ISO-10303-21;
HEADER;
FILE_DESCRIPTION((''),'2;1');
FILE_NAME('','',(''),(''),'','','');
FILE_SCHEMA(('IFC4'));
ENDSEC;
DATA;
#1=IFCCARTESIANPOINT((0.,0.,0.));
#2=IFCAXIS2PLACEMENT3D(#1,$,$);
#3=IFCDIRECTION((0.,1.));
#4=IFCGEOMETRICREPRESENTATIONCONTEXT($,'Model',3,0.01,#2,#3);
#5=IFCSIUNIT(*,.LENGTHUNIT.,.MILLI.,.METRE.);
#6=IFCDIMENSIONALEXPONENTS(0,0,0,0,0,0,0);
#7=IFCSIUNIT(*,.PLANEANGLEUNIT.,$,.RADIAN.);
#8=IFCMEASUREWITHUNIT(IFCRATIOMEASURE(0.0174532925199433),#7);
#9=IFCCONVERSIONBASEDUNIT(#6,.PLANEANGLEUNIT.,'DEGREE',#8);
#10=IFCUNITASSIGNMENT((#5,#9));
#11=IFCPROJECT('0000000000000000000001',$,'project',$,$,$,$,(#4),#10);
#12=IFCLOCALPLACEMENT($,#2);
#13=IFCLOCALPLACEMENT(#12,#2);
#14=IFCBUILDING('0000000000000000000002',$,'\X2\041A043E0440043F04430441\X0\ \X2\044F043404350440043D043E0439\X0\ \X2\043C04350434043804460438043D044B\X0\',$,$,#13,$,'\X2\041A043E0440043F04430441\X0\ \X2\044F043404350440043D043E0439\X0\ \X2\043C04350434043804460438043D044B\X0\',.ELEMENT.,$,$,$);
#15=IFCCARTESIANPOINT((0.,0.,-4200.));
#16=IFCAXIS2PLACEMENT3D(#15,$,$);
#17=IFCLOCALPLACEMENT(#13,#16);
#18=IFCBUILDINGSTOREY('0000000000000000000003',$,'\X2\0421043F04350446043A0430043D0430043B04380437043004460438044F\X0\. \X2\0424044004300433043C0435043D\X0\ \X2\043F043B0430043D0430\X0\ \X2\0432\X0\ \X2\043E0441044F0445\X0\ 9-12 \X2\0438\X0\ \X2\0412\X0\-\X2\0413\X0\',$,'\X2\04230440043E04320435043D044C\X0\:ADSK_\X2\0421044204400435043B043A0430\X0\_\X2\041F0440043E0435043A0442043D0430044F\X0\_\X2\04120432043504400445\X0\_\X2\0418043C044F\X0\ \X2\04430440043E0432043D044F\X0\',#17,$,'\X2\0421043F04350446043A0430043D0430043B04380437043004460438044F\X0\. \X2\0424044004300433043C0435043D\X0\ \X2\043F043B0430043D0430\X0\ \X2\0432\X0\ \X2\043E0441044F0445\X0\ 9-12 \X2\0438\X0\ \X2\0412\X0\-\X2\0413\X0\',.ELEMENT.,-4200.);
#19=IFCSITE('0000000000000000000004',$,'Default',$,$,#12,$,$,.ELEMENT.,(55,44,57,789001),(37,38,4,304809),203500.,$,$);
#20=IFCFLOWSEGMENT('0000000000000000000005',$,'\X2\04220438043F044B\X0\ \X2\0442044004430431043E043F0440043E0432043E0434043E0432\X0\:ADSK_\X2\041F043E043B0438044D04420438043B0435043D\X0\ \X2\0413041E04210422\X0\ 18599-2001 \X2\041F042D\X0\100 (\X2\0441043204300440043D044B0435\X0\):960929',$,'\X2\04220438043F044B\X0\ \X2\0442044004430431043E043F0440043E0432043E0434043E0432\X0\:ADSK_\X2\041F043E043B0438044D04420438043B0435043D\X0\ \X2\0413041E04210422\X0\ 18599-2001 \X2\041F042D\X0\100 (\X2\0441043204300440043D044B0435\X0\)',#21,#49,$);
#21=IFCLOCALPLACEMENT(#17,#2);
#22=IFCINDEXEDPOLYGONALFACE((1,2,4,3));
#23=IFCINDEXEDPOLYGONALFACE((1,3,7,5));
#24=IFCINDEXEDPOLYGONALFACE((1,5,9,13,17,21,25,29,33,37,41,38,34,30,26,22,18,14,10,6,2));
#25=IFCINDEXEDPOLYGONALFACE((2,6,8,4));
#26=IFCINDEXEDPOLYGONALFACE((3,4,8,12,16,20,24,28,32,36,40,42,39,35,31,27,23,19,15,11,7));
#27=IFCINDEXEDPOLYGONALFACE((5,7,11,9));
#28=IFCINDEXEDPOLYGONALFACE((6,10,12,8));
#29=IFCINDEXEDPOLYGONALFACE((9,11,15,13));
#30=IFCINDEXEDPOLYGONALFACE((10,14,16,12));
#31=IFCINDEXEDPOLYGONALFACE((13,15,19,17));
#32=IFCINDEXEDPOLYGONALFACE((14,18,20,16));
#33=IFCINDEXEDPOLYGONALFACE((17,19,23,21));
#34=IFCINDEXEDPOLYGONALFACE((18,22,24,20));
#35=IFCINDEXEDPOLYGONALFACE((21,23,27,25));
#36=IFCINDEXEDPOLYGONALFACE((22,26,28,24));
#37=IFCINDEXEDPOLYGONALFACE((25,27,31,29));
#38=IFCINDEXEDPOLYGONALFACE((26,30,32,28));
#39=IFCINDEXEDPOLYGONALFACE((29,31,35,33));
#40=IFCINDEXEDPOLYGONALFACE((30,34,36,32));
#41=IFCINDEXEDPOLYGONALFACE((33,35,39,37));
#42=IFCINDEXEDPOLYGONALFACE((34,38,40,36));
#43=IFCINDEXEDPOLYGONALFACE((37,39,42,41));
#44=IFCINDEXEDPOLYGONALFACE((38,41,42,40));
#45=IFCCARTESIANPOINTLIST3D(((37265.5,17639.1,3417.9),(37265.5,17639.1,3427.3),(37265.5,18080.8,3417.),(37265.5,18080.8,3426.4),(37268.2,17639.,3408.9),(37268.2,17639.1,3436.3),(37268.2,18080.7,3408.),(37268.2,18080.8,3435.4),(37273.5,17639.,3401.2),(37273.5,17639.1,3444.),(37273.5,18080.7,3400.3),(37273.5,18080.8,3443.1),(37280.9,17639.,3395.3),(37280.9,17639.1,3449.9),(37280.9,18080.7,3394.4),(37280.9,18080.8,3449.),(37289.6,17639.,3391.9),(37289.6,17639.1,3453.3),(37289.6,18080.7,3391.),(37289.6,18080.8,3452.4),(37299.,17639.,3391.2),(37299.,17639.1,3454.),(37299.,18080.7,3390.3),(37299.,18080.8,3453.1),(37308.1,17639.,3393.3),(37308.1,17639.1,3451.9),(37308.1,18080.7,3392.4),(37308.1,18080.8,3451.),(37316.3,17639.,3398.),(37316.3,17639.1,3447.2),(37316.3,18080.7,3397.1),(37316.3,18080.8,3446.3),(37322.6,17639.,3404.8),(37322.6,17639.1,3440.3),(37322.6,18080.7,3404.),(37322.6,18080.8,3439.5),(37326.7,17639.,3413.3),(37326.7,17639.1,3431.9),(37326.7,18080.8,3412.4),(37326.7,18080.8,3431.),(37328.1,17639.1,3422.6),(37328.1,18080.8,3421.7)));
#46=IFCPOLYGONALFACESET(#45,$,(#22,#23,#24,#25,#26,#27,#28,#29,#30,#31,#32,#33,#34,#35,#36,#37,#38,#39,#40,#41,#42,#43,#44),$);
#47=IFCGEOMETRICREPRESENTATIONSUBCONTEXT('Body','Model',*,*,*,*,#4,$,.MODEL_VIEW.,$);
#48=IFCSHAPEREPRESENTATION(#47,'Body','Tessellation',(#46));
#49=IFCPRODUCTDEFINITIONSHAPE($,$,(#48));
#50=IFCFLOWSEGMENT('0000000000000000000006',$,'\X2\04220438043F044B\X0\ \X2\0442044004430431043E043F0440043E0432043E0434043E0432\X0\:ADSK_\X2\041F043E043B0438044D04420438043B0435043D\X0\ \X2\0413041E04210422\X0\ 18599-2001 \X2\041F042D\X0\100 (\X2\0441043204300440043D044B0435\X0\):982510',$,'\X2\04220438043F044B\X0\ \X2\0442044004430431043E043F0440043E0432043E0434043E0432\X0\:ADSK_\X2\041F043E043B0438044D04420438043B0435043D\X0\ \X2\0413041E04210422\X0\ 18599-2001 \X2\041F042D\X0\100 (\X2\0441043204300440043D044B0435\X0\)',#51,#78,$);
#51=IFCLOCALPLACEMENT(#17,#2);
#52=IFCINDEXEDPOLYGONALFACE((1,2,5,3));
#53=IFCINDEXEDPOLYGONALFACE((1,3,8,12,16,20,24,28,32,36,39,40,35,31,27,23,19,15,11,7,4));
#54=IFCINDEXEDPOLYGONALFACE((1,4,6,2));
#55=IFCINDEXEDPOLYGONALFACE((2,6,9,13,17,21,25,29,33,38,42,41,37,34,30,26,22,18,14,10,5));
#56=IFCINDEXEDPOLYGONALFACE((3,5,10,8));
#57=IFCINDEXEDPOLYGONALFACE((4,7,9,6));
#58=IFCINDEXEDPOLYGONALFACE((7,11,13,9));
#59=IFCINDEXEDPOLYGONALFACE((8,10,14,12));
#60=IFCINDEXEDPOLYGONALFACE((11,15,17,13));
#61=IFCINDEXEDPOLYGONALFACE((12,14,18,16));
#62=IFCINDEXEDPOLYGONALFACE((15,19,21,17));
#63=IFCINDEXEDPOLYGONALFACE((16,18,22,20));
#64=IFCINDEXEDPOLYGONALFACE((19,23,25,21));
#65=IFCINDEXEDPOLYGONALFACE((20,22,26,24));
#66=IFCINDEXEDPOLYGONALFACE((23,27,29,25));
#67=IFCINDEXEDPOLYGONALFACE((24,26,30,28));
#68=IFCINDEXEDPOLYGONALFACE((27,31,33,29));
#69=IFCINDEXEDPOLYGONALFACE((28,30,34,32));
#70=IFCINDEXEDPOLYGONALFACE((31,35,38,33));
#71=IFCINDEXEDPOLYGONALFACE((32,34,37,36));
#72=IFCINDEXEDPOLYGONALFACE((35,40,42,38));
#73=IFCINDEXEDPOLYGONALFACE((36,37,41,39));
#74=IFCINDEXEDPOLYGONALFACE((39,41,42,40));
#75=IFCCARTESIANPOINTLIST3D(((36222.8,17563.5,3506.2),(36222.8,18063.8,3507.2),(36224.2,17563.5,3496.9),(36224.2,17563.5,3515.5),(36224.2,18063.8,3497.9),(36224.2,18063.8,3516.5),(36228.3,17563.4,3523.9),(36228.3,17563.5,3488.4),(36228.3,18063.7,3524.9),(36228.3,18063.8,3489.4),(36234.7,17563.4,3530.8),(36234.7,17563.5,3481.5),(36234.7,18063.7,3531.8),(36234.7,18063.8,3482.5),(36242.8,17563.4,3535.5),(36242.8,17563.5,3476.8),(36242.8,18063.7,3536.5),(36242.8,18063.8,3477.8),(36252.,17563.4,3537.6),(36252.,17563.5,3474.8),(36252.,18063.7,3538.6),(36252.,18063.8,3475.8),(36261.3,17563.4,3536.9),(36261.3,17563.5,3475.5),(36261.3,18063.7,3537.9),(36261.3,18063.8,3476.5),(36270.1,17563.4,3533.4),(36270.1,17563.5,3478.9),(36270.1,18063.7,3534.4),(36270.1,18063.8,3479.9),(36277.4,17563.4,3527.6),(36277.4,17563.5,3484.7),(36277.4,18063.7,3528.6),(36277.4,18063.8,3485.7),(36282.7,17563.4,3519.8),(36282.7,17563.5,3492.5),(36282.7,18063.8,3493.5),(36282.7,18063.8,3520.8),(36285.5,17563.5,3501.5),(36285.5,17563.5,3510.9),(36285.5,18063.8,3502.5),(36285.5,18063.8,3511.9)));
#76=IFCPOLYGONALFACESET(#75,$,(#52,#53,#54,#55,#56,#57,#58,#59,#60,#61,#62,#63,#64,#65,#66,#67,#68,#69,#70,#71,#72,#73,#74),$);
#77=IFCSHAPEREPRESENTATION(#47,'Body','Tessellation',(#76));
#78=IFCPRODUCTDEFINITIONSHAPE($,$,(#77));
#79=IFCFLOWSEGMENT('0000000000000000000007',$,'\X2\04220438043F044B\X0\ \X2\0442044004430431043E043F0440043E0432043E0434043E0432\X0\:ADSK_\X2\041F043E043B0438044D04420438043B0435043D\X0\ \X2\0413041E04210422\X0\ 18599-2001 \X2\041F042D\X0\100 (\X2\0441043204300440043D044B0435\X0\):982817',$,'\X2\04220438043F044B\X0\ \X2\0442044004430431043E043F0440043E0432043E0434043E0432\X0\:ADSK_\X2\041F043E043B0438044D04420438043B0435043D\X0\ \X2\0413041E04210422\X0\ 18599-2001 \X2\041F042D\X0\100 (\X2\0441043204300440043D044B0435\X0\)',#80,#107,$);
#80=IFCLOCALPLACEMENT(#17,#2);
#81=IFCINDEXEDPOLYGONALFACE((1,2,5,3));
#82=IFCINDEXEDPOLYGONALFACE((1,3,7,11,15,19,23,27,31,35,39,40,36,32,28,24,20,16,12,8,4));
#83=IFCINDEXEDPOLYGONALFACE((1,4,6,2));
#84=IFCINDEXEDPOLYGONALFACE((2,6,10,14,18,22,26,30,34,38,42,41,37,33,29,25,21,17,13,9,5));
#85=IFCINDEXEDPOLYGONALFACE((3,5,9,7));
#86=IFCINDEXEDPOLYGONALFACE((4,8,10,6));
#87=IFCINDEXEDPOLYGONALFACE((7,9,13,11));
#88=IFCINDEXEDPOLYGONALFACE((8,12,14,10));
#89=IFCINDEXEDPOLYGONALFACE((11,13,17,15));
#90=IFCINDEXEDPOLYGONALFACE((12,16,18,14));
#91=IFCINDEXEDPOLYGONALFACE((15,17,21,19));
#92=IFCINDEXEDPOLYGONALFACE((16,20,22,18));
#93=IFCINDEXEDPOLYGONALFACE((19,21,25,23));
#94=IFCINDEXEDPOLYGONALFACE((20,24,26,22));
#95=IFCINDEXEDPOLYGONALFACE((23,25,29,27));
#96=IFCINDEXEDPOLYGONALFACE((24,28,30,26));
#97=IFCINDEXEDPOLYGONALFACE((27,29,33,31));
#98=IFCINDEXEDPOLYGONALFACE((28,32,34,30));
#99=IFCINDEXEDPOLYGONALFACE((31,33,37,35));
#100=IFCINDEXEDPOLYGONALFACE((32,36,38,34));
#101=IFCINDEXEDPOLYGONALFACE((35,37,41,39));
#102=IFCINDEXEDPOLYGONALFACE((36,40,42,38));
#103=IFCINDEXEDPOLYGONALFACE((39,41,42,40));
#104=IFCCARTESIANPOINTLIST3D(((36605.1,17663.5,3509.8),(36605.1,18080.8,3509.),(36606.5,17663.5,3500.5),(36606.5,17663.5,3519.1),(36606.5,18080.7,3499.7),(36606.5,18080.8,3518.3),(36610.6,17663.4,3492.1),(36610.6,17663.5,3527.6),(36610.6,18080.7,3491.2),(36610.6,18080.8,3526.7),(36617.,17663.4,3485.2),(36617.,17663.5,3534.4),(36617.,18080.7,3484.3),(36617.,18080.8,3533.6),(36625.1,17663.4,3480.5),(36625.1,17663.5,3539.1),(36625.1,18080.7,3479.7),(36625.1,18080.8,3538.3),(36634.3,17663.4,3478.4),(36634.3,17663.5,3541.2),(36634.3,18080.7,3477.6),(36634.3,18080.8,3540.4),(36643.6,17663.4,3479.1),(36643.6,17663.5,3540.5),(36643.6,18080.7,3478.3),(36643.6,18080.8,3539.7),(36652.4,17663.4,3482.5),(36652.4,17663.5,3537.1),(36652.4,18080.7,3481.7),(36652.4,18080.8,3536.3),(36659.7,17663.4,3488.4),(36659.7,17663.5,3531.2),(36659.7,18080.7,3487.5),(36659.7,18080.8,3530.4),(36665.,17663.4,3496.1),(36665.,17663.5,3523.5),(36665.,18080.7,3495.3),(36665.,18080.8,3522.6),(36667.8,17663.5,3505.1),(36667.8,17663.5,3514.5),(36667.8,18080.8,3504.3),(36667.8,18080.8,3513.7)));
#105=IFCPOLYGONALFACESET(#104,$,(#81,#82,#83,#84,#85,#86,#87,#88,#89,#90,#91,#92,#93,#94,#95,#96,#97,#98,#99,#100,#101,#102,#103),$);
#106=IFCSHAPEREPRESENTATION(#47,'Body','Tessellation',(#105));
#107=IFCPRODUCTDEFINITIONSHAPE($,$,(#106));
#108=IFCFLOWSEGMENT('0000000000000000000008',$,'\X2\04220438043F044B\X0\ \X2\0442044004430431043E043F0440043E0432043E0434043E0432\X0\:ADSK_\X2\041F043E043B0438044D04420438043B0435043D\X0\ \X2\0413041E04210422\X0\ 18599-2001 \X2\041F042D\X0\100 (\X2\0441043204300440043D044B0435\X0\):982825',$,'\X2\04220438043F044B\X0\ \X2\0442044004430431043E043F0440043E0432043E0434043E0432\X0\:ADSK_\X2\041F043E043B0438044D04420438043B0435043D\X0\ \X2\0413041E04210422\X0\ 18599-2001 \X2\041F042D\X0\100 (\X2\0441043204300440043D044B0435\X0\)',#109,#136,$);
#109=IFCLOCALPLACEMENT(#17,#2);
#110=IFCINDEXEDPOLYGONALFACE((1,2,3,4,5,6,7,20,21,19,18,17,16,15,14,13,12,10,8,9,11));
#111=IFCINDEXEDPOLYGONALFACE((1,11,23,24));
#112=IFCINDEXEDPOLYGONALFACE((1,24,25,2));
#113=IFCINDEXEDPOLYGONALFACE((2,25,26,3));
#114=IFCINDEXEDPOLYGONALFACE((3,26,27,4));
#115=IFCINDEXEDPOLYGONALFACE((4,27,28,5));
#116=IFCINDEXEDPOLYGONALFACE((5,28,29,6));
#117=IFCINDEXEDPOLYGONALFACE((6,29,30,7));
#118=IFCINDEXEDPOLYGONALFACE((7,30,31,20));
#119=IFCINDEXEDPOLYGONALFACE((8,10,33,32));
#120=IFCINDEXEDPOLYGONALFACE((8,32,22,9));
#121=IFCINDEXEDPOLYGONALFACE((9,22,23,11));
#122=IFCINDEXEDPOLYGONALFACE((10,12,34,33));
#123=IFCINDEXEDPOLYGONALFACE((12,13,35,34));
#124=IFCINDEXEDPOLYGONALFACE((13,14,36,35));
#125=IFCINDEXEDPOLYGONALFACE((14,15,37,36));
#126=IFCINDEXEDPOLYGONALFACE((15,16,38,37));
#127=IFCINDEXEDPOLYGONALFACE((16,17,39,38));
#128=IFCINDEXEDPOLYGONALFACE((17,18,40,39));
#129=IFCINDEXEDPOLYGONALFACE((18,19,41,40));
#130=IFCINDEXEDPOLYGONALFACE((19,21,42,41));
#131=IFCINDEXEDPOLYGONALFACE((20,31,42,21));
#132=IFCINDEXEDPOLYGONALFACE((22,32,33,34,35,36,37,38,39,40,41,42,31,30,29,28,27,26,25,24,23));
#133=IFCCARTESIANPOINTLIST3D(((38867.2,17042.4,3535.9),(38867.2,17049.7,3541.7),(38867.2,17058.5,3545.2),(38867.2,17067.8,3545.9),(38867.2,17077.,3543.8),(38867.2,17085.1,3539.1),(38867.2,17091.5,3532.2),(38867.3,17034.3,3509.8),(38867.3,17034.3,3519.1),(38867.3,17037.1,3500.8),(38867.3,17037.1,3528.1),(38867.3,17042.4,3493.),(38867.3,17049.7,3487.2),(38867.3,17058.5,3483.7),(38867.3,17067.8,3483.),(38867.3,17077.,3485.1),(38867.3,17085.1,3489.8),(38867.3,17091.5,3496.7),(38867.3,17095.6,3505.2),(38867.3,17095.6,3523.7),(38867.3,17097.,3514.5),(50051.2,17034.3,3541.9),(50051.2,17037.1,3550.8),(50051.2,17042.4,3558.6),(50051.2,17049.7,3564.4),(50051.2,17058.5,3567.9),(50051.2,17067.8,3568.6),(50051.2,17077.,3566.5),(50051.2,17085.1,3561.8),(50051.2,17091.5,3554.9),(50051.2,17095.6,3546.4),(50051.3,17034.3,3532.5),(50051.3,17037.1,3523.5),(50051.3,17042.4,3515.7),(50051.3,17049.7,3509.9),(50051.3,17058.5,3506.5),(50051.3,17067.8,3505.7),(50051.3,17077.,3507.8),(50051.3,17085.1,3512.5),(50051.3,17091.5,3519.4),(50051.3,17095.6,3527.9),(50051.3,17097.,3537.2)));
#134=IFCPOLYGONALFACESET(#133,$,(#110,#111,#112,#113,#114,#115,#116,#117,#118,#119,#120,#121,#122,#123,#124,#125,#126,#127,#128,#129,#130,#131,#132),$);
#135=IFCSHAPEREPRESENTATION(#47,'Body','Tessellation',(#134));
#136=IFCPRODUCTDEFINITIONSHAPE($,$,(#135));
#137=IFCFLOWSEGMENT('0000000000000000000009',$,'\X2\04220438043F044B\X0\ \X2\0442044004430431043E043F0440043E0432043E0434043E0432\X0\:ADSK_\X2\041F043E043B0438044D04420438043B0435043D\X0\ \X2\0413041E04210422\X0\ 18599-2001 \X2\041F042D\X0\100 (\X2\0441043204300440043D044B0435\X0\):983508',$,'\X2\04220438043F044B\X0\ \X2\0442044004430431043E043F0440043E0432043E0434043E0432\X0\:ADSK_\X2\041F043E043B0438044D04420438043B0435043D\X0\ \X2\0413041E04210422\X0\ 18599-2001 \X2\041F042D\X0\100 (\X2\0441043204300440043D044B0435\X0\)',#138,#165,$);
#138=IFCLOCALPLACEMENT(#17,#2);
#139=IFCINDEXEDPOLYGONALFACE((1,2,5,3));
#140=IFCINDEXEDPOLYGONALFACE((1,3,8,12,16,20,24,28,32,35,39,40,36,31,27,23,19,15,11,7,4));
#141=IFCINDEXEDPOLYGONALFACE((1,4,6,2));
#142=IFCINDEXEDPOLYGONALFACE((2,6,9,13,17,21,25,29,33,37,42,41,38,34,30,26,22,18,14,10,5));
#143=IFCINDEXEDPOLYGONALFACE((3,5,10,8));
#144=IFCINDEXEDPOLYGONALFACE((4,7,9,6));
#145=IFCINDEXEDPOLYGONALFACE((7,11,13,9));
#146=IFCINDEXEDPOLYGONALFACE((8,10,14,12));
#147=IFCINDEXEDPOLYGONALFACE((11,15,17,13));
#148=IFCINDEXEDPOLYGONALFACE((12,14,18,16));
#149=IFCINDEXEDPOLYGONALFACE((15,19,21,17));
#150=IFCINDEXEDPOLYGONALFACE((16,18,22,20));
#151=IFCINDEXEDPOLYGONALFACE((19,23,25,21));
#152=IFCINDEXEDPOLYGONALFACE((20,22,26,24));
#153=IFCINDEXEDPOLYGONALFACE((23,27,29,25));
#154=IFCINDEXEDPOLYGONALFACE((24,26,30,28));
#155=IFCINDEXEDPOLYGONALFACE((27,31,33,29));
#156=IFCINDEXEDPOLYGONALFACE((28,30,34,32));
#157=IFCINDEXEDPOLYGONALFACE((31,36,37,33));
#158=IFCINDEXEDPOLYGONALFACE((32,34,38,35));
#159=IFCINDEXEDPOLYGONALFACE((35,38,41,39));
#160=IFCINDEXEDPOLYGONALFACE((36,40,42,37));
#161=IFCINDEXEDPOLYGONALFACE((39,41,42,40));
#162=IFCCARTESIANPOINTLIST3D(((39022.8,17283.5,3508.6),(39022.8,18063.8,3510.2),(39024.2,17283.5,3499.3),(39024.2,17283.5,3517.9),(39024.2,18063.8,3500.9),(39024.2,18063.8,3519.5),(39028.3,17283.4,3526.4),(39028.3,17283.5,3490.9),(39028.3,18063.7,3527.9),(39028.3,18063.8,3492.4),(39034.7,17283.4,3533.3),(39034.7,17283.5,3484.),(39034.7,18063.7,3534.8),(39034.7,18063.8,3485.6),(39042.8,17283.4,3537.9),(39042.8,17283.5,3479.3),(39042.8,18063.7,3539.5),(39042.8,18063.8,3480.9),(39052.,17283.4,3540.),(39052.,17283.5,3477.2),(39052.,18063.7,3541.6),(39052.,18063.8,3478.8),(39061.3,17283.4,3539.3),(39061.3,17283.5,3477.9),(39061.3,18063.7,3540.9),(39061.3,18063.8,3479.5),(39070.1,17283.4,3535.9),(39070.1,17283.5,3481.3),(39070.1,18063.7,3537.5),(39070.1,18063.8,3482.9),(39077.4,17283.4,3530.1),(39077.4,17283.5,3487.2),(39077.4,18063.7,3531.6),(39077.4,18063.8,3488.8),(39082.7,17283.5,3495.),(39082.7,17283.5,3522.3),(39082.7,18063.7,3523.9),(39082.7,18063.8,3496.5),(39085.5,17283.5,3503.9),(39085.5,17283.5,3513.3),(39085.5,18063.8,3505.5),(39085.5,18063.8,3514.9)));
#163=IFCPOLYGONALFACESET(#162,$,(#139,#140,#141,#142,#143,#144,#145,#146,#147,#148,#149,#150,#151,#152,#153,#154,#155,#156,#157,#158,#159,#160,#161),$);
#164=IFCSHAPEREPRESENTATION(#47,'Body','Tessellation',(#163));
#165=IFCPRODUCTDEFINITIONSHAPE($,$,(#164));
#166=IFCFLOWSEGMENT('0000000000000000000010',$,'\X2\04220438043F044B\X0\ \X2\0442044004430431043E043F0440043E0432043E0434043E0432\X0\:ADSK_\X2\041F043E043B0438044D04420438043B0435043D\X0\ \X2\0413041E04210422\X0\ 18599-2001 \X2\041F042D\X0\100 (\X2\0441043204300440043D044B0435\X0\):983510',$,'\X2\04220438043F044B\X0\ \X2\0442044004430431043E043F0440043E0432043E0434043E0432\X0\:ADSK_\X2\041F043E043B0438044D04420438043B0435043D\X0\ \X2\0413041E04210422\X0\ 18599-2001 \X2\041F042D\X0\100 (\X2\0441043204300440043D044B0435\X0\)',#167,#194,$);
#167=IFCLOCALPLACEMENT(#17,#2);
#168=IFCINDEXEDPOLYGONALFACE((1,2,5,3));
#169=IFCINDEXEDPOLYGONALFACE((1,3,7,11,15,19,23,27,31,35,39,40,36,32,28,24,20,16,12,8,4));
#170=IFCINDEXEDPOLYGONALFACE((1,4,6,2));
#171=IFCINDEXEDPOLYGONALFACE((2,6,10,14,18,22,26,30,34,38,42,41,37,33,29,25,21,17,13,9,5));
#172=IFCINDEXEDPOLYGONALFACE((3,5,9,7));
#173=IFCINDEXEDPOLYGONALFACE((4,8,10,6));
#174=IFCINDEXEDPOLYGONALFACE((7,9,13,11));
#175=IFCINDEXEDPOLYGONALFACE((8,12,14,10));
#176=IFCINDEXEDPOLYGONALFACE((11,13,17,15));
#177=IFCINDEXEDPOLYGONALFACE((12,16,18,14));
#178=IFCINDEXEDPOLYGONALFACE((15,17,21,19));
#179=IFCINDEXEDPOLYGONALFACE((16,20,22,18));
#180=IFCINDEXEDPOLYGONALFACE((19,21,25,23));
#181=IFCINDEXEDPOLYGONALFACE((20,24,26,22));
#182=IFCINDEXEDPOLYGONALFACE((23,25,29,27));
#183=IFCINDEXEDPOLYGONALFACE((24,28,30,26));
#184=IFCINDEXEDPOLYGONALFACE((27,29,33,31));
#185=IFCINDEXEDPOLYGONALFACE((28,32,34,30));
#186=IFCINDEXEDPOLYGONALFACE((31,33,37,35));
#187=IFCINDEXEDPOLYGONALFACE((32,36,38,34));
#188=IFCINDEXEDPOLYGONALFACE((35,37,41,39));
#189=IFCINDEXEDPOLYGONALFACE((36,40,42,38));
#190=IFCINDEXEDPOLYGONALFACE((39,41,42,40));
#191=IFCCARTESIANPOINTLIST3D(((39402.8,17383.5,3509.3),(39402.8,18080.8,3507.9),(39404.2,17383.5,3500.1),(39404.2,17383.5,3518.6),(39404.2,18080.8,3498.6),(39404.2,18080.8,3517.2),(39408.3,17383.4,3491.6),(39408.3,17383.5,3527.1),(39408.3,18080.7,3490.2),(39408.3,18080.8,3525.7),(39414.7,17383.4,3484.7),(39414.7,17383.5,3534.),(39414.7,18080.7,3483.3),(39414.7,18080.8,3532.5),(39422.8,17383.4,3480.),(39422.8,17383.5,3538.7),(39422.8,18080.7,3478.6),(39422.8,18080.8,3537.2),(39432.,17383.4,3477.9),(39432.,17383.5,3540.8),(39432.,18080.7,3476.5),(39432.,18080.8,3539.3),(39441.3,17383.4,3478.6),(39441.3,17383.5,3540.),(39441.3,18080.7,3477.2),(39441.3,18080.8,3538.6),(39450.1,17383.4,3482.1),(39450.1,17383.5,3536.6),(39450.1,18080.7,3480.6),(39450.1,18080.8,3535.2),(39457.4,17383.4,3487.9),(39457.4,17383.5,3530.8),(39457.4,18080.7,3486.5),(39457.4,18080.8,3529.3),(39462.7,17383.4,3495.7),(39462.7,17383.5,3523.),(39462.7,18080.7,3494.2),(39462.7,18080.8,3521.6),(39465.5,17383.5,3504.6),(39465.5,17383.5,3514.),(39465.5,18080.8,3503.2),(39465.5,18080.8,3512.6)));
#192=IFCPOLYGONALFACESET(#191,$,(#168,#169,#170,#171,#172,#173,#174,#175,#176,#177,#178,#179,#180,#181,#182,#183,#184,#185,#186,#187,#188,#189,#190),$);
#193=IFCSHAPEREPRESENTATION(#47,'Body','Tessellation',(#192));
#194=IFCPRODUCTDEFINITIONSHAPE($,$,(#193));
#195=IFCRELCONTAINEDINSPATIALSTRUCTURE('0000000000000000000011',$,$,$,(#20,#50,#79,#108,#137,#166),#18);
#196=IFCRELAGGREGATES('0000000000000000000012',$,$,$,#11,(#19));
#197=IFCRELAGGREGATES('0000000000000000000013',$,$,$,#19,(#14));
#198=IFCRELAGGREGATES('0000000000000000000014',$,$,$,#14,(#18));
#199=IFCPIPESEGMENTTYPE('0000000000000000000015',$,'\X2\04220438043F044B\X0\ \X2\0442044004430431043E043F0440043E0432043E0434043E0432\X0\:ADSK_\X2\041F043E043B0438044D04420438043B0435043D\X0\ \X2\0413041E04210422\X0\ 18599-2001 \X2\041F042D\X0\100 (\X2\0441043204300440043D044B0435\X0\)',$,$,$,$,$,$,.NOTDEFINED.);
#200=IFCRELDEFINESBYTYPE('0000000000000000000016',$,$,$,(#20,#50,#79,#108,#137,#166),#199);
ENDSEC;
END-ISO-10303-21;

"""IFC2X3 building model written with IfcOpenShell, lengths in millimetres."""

from ifc_helpers import new_model, entity, si_unit, converted_unit, direction, frame, frame_2d, origin, origin_2d_with_axis, place, context, subcontext, project, spatial, circle, extrude, type_object, element, save


model = new_model("IFC2X3")

# Units and contexts
model_context = context("Model", 3, precision=0.01, world=origin(), true_north=direction((0.0, 1.0)))
body_context = subcontext(model_context, "Body", "Model", "MODEL_VIEW")
ifc_project = project(units=[si_unit("LENGTHUNIT", "METRE", prefix="MILLI"), converted_unit("PLANEANGLEUNIT", "DEGREE", entity("IfcRatioMeasure", 0.0174532925199433), si_unit("PLANEANGLEUNIT", "RADIAN"), dimensions=[0, 0, 0, 0, 0, 0, 0])], contexts=[model_context])

# Site, building, storey
site_placement = place(None, frame((0.0, 0.0, 0.0)))
site = spatial("IfcSite", under=ifc_project, at=site_placement, Name="Default", CompositionType="ELEMENT", RefLatitude=(55, 44, 57, 789001), RefLongitude=(37, 38, 4, 304809), RefElevation=203500.0)
building_placement = place(site_placement, origin())
building = spatial("IfcBuilding", under=site, at=building_placement, Name="Корпус ядерной медицины", LongName="Корпус ядерной медицины", CompositionType="ELEMENT")
storey_placement = place(building_placement, frame((0.0, 0.0, -4200.0)))
storey = spatial("IfcBuildingStorey", under=building, at=storey_placement, Name="Спецканализация. Фрагмен плана в осях 9-12 и В-Г", ObjectType="Уровень:ADSK_Стрелка_Проектная_Вверх_Имя уровня", LongName="Спецканализация. Фрагмен плана в осях 9-12 и В-Г", CompositionType="ELEMENT", Elevation=-4200.0)

# Flow segments
pipe_segment_type = type_object("IfcPipeSegmentType", Name="Типы трубопроводов:ADSK_Полиэтилен ГОСТ 18599-2001 ПЭ100 (сварные)", PredefinedType="NOTDEFINED")
flow_segment_1_placement = place(storey_placement, frame((37263.5, 17639.0, 3388.6)))
element("IfcFlowSegment", 1, at=flow_segment_1_placement, inside=storey, type_object=pipe_segment_type, Name="Типы трубопроводов:ADSK_Полиэтилен ГОСТ 18599-2001 ПЭ100 (сварные):960929", ObjectType="Типы трубопроводов:ADSK_Полиэтилен ГОСТ 18599-2001 ПЭ100 (сварные)", context=body_context, shape_type="SweptSolid", body=[
    extrude(circle(Radius=31.5, at=origin_2d_with_axis()), frame((33.1, 0.1, 34.0), z_axis=(0.0, 0.999998, -0.001981), x_axis=(1.0, 0.0, 0.0)), (0.0, 0.0, 1.0), 441.7),
])
flow_segment_2_placement = place(storey_placement, frame((36221.2, 17563.4, 3473.1)))
element("IfcFlowSegment", 2, at=flow_segment_2_placement, inside=storey, type_object=pipe_segment_type, Name="Типы трубопроводов:ADSK_Полиэтилен ГОСТ 18599-2001 ПЭ100 (сварные):982510", ObjectType="Типы трубопроводов:ADSK_Полиэтилен ГОСТ 18599-2001 ПЭ100 (сварные)", context=body_context, shape_type="SweptSolid", body=[
    extrude(circle(Radius=31.5, at=origin_2d_with_axis()), frame((33.1, 0.1, 33.1), z_axis=(0.0, 0.999998, 0.002), x_axis=(-1.0, 0.0, 0.0)), (0.0, 0.0, 1.0), 500.3),
])
flow_segment_3_placement = place(storey_placement, frame((36603.5, 17663.4, 3475.9)))
element("IfcFlowSegment", 3, at=flow_segment_3_placement, inside=storey, type_object=pipe_segment_type, Name="Типы трубопроводов:ADSK_Полиэтилен ГОСТ 18599-2001 ПЭ100 (сварные):982817", ObjectType="Типы трубопроводов:ADSK_Полиэтилен ГОСТ 18599-2001 ПЭ100 (сварные)", context=body_context, shape_type="SweptSolid", body=[
    extrude(circle(Radius=31.5, at=origin_2d_with_axis()), frame((33.1, 417.4, 33.1), z_axis=(0.0, -0.999998, 0.002), x_axis=(-1.0, 0.0, 0.0)), (0.0, 0.0, 1.0), 417.3),
])
flow_segment_4_placement = place(storey_placement, frame((38867.2, 17032.4, 3481.4)))
element("IfcFlowSegment", 4, at=flow_segment_4_placement, inside=storey, type_object=pipe_segment_type, Name="Типы трубопроводов:ADSK_Полиэтилен ГОСТ 18599-2001 ПЭ100 (сварные):982825", ObjectType="Типы трубопроводов:ADSK_Полиэтилен ГОСТ 18599-2001 ПЭ100 (сварные)", context=body_context, shape_type="SweptSolid", body=[
    extrude(circle(Radius=31.5, at=frame_2d((0.0, 0.0), x_axis=(1.0, 0.0))), frame((0.1, 33.1, 33.1), z_axis=(0.999998, 0.0, 0.002031), x_axis=(0.0, 1.0, 0.0)), (0.0, 0.0, 1.0), 11184.0),
])
flow_segment_5_placement = place(storey_placement, frame((39021.2, 17283.4, 3475.5)))
element("IfcFlowSegment", 5, at=flow_segment_5_placement, inside=storey, type_object=pipe_segment_type, Name="Типы трубопроводов:ADSK_Полиэтилен ГОСТ 18599-2001 ПЭ100 (сварные):983508", ObjectType="Типы трубопроводов:ADSK_Полиэтилен ГОСТ 18599-2001 ПЭ100 (сварные)", context=body_context, shape_type="SweptSolid", body=[
    extrude(circle(Radius=31.5, at=origin_2d_with_axis()), frame((33.1, 0.1, 33.1), z_axis=(0.0, 0.999998, 0.002), x_axis=(-1.0, 0.0, 0.0)), (0.0, 0.0, 1.0), 780.3),
])
flow_segment_6_placement = place(storey_placement, frame((39401.2, 17383.4, 3474.8)))
element("IfcFlowSegment", 6, at=flow_segment_6_placement, inside=storey, type_object=pipe_segment_type, Name="Типы трубопроводов:ADSK_Полиэтилен ГОСТ 18599-2001 ПЭ100 (сварные):983510", ObjectType="Типы трубопроводов:ADSK_Полиэтилен ГОСТ 18599-2001 ПЭ100 (сварные)", context=body_context, shape_type="SweptSolid", body=[
    extrude(circle(Radius=31.5, at=frame_2d((0.0, 0.0), x_axis=(1.0, 0.0))), frame((33.1, 0.1, 34.5), z_axis=(0.000002, 0.999998, -0.00204), x_axis=(-1.0, 0.000002, 0.0)), (0.0, 0.0, 1.0), 697.3),
])

save(model, "model.ifc")
